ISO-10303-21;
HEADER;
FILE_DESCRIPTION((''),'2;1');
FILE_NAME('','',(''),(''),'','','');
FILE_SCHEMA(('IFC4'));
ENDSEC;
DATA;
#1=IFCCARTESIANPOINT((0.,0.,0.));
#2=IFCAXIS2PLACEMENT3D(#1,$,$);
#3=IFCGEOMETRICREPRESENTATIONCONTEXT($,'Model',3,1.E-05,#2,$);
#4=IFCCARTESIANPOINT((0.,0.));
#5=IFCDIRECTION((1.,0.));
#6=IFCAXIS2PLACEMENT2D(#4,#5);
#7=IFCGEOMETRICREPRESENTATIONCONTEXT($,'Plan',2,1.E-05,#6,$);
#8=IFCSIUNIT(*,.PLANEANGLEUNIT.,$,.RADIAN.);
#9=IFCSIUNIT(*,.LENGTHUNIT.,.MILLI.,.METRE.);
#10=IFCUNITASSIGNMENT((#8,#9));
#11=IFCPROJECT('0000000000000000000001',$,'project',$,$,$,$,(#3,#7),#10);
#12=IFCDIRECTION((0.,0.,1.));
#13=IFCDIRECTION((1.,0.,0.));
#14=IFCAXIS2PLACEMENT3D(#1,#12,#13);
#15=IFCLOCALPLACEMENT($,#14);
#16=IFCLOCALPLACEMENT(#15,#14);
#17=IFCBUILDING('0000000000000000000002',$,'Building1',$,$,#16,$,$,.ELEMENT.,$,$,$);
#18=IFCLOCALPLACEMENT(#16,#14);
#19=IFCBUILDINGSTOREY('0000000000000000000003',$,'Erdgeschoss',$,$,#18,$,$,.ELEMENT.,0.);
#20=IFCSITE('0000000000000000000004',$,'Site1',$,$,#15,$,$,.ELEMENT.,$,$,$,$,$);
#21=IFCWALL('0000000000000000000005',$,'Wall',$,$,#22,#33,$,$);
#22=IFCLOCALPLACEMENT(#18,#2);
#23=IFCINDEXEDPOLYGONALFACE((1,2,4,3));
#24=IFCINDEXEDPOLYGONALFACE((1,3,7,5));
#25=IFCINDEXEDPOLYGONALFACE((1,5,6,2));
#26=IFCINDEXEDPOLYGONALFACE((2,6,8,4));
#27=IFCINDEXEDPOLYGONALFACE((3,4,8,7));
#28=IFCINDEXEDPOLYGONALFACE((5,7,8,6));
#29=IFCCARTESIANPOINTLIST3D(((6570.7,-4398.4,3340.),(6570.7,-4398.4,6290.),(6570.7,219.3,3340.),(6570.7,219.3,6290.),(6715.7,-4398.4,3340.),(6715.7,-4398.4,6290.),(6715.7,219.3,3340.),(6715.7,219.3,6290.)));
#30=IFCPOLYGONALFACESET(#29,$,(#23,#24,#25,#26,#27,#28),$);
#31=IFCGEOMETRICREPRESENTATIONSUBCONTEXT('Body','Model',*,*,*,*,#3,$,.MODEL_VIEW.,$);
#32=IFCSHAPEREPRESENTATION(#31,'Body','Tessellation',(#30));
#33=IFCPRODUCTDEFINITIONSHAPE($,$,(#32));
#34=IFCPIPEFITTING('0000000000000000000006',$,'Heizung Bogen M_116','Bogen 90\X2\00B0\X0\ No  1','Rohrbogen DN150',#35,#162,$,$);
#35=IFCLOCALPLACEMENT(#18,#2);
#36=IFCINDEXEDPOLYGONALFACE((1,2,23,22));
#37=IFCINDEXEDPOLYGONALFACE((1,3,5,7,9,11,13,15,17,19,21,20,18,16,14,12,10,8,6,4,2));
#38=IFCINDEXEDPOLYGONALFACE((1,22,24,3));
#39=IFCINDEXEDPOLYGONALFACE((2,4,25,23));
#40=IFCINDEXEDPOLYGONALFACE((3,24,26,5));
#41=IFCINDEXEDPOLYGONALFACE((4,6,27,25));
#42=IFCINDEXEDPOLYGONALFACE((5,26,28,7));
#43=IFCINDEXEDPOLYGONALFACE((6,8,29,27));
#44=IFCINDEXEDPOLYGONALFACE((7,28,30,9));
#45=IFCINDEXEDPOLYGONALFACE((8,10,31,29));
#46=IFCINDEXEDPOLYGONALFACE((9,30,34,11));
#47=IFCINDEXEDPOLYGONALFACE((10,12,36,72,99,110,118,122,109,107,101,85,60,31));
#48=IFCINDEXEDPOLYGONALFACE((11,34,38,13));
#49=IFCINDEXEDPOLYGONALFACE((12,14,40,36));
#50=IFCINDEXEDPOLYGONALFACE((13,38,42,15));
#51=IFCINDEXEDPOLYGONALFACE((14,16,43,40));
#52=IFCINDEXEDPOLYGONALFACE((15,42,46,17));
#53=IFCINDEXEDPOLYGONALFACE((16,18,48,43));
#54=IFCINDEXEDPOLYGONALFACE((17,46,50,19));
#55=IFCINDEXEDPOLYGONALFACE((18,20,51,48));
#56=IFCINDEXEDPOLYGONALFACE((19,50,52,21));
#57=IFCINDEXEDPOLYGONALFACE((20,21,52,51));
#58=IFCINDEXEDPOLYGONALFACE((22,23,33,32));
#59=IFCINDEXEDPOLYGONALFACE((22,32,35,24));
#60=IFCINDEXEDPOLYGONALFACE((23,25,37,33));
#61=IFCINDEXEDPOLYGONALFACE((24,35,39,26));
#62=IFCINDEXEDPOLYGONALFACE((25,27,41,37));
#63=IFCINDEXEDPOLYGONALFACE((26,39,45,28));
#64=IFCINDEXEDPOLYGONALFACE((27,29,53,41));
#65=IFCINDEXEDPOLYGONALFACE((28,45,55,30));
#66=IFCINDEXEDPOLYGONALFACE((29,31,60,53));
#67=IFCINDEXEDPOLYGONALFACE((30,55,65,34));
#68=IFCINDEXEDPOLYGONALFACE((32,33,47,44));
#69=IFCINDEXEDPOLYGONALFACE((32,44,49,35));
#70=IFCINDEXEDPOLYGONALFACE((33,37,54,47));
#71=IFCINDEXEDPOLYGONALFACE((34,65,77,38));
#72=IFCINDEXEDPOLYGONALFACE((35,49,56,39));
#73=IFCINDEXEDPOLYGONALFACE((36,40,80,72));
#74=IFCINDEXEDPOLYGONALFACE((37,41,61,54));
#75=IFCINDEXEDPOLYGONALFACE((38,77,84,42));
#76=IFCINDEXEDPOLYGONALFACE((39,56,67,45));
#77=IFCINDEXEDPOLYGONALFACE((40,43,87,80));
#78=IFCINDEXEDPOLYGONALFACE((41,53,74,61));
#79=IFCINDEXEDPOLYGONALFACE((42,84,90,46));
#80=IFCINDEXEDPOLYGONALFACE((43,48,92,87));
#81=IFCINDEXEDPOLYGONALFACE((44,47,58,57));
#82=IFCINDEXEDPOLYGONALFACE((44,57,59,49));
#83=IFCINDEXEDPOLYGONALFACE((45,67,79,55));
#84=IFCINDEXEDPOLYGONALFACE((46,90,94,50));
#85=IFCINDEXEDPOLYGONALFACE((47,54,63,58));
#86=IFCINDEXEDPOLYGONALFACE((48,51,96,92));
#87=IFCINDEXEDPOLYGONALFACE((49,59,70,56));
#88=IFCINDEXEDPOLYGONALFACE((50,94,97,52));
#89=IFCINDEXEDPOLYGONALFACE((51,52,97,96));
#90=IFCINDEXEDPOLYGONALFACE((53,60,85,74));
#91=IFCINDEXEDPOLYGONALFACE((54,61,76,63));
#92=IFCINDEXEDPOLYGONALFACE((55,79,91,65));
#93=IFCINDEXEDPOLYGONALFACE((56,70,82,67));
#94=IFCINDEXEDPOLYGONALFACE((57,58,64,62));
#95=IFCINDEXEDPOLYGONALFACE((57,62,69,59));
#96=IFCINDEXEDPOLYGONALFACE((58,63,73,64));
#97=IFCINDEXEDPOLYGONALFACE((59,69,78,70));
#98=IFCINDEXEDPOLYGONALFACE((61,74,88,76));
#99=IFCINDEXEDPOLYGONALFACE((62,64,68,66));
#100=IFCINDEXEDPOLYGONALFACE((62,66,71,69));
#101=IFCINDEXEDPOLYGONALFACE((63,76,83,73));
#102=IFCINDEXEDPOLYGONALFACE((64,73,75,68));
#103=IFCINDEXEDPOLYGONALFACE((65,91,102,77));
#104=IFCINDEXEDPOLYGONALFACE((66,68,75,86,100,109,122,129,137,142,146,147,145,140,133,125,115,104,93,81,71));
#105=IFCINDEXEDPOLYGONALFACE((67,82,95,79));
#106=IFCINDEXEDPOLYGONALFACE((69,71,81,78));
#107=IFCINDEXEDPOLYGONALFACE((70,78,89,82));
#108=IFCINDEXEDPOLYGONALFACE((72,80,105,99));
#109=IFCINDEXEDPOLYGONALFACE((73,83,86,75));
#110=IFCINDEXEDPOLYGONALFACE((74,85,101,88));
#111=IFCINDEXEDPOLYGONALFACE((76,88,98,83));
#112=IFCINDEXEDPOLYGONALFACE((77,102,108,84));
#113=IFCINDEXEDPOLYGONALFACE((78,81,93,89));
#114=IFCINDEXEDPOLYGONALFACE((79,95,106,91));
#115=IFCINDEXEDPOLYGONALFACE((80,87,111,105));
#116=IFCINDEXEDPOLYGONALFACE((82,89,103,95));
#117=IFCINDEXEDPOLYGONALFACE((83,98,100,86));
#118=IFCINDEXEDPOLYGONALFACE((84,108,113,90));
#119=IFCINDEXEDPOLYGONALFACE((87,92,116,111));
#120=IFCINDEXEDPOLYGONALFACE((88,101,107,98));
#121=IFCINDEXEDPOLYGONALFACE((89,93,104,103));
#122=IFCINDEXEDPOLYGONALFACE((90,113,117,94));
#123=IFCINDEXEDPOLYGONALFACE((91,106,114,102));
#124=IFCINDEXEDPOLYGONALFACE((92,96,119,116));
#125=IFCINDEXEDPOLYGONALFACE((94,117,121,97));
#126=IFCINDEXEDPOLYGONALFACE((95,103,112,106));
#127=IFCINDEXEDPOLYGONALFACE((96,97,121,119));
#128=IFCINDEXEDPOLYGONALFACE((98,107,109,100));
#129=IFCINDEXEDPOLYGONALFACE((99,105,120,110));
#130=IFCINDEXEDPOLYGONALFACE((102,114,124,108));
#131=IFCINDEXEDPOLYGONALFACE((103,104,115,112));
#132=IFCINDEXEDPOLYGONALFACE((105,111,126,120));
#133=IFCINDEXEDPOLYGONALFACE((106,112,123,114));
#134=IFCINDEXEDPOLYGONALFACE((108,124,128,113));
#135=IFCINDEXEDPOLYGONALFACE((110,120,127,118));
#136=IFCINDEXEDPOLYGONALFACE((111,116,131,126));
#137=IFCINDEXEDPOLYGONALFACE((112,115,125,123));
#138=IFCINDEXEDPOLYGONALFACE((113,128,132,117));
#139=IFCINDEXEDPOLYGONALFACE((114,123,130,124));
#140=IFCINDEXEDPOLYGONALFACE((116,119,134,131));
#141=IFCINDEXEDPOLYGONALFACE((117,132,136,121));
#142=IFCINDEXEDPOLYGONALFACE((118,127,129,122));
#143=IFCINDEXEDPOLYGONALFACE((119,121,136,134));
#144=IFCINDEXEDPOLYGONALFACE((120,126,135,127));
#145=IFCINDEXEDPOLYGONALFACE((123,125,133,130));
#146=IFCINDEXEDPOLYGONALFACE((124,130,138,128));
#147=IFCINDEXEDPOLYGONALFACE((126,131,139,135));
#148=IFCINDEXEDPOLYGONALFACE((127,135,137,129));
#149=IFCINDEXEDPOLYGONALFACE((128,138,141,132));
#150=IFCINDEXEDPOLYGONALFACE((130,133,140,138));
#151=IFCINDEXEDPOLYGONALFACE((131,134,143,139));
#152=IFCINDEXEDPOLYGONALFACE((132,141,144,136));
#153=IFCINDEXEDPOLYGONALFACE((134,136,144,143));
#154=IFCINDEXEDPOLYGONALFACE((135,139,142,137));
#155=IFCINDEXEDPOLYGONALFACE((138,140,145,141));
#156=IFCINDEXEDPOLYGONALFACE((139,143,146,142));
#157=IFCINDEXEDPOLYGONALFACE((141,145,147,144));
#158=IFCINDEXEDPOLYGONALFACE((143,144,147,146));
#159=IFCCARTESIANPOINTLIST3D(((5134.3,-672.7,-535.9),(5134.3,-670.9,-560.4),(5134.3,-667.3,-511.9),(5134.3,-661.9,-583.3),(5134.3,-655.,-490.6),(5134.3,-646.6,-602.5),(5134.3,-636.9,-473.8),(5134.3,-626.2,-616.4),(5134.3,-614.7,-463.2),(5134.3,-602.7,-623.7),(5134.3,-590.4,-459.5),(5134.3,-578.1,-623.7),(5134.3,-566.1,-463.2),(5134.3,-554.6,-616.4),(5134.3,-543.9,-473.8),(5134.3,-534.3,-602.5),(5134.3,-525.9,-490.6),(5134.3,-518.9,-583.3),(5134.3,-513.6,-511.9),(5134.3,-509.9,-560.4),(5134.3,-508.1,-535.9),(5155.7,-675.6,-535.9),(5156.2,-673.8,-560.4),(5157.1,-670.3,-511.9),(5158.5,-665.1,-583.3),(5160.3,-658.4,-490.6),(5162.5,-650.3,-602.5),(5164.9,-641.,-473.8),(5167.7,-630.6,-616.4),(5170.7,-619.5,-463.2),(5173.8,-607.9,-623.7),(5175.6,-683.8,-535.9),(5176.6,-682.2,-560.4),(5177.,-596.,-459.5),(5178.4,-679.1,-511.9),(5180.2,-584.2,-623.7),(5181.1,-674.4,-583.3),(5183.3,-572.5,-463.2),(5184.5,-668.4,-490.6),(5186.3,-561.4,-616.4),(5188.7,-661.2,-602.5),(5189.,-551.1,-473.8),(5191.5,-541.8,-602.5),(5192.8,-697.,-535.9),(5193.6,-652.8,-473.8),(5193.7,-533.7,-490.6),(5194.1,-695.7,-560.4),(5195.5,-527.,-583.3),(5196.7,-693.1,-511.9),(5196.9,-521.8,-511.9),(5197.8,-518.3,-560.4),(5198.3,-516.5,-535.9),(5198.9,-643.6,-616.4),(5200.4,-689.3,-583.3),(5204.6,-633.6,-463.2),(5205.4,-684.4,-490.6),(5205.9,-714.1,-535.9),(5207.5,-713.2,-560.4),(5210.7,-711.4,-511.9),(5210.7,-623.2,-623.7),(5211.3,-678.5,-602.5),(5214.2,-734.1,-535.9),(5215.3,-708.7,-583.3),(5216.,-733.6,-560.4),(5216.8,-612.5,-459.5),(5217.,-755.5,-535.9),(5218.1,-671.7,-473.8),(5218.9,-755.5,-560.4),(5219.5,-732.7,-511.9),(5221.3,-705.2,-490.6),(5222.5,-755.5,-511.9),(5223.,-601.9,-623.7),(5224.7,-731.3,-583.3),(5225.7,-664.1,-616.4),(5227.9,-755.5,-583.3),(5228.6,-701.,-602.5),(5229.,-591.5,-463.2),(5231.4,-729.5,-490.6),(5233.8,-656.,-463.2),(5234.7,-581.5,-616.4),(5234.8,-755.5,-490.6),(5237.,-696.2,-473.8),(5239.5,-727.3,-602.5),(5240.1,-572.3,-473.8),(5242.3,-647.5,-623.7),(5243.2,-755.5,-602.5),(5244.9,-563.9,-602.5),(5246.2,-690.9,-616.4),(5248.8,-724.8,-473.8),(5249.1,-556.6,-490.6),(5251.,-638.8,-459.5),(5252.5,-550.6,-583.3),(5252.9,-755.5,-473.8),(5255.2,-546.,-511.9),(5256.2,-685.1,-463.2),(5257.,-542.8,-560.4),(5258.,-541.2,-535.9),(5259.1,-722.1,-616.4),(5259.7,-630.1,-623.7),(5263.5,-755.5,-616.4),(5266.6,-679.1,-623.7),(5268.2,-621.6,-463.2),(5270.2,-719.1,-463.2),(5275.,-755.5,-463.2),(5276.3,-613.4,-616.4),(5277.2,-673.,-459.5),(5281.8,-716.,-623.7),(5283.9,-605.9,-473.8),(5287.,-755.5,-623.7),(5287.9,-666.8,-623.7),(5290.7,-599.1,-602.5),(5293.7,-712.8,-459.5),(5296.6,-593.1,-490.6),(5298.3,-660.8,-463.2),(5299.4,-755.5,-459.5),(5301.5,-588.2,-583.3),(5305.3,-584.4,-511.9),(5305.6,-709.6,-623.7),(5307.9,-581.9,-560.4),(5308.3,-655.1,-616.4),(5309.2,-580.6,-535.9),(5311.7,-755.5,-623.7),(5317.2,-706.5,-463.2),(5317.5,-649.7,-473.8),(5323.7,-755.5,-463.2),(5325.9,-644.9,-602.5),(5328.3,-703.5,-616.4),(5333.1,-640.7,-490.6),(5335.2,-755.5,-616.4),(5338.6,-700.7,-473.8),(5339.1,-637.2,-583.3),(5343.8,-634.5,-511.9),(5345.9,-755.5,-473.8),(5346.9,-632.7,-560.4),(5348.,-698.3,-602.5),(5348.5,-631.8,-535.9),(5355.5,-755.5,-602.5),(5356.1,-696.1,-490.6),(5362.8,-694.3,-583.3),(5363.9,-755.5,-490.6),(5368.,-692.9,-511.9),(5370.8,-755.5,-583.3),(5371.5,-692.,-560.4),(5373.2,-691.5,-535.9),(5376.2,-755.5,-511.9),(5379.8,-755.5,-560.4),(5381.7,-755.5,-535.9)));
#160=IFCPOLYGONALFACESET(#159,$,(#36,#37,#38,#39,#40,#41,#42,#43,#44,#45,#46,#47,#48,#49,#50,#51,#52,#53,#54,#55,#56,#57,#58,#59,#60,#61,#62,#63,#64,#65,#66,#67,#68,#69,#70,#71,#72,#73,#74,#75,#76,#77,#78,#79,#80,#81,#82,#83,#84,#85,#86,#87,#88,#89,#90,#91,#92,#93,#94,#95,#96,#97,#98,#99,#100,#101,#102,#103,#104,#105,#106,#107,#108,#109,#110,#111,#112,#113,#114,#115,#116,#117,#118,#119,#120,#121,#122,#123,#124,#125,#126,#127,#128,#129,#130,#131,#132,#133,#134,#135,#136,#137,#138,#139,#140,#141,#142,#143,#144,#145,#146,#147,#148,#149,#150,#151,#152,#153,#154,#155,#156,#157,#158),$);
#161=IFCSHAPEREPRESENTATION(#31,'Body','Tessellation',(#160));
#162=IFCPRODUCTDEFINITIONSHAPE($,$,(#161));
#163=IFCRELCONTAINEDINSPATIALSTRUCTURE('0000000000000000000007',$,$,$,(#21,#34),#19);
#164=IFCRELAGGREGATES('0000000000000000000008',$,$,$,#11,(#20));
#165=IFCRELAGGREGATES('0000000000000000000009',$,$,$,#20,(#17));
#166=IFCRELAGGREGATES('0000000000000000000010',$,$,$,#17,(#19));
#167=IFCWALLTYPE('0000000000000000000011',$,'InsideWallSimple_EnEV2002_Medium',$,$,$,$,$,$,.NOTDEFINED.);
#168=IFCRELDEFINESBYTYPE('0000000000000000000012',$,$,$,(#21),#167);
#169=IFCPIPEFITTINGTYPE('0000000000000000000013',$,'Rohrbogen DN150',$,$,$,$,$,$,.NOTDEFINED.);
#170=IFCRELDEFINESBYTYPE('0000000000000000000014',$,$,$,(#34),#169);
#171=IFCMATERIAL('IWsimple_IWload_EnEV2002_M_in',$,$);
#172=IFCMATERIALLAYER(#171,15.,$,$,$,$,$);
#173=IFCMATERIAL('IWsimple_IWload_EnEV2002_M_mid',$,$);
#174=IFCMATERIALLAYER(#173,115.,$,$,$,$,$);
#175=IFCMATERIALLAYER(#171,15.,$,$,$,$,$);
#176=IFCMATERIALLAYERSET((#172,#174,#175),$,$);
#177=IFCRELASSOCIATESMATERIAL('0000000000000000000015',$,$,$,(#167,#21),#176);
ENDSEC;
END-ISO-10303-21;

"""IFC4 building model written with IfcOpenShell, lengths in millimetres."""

from ifc_helpers import new_model, entity, si_unit, frame, origin, origin_with_axes, origin_2d_with_axis, place, context, subcontext, project, spatial, indexed_curve, outline, extrude, source, transform, mapped, material, layer, layer_set, layer_usage, type_object, element, save


model = new_model("IFC4")

# Units and contexts
model_context = context("Model", 3, precision=1e-05, world=origin())
plan_context = context("Plan", 2, precision=1e-05, world=origin_2d_with_axis())
body_context = subcontext(model_context, "Body", "Model", "MODEL_VIEW")
ifc_project = project(units=[si_unit("PLANEANGLEUNIT", "RADIAN"), si_unit("LENGTHUNIT", "METRE", prefix="MILLI")], contexts=[model_context, plan_context])

# Site, building, storey
site_placement = place(None, origin_with_axes())
site = spatial("IfcSite", under=ifc_project, at=site_placement, Name="Site1", CompositionType="ELEMENT")
building_placement = place(site_placement, origin_with_axes())
building = spatial("IfcBuilding", under=site, at=building_placement, Name="Building1", CompositionType="ELEMENT")
storey_placement = place(building_placement, origin_with_axes())
storey = spatial("IfcBuildingStorey", under=building, at=storey_placement, Name="Erdgeschoss", CompositionType="ELEMENT", Elevation=0.0)

# Wall
ifc_material_1 = material(Name="IWsimple_IWload_EnEV2002_M_in")
ifc_layer_1 = layer(ifc_material_1, 15.0)
ifc_material_2 = material(Name="IWsimple_IWload_EnEV2002_M_mid")
ifc_layer_2 = layer(ifc_material_2, 115.0)
ifc_layer_3 = layer(ifc_material_1, 15.0)
ifc_layer_set_1 = layer_set([ifc_layer_1, ifc_layer_2, ifc_layer_3])
ifc_layer_usage_1 = layer_usage(ifc_layer_set_1, "AXIS2", "POSITIVE", 0.0)
wall_type = type_object("IfcWallType", Name="InsideWallSimple_EnEV2002_Medium", PredefinedType="NOTDEFINED", material=ifc_layer_set_1)
wall_placement = place(storey_placement, frame((6570.7, 219.3, 3340.0), z_axis=(0.0, 0.0, 1.0), x_axis=(-0.000001, -1.0, 0.0)))
element("IfcWall", 1, at=wall_placement, inside=storey, type_object=wall_type, material=ifc_layer_usage_1, Name="Wall", context=body_context, shape_type="SweptSolid", body=[
    extrude(outline(indexed_curve([(0.0, 0.0), (0.0, 145.0), (4617.6, 145.0), (4617.6, 0.0), (0.0, 0.0)], self_intersect=False)), origin_with_axes(), (0.0, 0.0, 1.0), 2950.0),
])

# Pipe fitting
pipe_fitting_type_1 = type_object("IfcPipeFittingType", Name="Rohrbogen DN150", PredefinedType="NOTDEFINED")
shared_shape_1 = source(origin_with_axes(), body_context, "Body", "SolidModel", [
    entity("IfcRevolvedAreaSolid", entity("IfcCircleProfileDef", "AREA", None, entity("IfcAxis2Placement2D", entity("IfcCartesianPoint", [0.0, 0.0]), entity("IfcDirection", [1.0, 0.0])), 82.5), entity("IfcAxis2Placement3D", entity("IfcCartesianPoint", [-123.8, 41.3, 0.0]), entity("IfcDirection", [1.0, 0.0, 0.0]), entity("IfcDirection", [0.0, 0.0, 1.0])), entity("IfcAxis1Placement", entity("IfcCartesianPoint", [0.0, 165.1, 0.0]), entity("IfcDirection", [-1.0, 0.0, 0.0])), 1.570796),
])
pipe_fitting_1_placement = place(storey_placement, frame((5258.1, -631.7, -542.0), z_axis=(0.0, 0.0, 1.0), x_axis=(1.0, 0.0, 0.0)))
element("IfcPipeFitting", 2, at=pipe_fitting_1_placement, inside=storey, type_object=pipe_fitting_type_1, Name="Heizung Bogen M_116", Description="Bogen 90° No  1", ObjectType="Rohrbogen DN150", context=body_context, shape_type="MappedRepresentation", body=[
    mapped(shared_shape_1, transform((0.0, 0.0, 0.0), x_axis=(1.0, 0.0, 0.0), y_axis=(0.0, 1.0, 0.0), z_axis=(0.0, 0.0, 1.0), scale=1.0)),
])

save(model, "model.ifc")
